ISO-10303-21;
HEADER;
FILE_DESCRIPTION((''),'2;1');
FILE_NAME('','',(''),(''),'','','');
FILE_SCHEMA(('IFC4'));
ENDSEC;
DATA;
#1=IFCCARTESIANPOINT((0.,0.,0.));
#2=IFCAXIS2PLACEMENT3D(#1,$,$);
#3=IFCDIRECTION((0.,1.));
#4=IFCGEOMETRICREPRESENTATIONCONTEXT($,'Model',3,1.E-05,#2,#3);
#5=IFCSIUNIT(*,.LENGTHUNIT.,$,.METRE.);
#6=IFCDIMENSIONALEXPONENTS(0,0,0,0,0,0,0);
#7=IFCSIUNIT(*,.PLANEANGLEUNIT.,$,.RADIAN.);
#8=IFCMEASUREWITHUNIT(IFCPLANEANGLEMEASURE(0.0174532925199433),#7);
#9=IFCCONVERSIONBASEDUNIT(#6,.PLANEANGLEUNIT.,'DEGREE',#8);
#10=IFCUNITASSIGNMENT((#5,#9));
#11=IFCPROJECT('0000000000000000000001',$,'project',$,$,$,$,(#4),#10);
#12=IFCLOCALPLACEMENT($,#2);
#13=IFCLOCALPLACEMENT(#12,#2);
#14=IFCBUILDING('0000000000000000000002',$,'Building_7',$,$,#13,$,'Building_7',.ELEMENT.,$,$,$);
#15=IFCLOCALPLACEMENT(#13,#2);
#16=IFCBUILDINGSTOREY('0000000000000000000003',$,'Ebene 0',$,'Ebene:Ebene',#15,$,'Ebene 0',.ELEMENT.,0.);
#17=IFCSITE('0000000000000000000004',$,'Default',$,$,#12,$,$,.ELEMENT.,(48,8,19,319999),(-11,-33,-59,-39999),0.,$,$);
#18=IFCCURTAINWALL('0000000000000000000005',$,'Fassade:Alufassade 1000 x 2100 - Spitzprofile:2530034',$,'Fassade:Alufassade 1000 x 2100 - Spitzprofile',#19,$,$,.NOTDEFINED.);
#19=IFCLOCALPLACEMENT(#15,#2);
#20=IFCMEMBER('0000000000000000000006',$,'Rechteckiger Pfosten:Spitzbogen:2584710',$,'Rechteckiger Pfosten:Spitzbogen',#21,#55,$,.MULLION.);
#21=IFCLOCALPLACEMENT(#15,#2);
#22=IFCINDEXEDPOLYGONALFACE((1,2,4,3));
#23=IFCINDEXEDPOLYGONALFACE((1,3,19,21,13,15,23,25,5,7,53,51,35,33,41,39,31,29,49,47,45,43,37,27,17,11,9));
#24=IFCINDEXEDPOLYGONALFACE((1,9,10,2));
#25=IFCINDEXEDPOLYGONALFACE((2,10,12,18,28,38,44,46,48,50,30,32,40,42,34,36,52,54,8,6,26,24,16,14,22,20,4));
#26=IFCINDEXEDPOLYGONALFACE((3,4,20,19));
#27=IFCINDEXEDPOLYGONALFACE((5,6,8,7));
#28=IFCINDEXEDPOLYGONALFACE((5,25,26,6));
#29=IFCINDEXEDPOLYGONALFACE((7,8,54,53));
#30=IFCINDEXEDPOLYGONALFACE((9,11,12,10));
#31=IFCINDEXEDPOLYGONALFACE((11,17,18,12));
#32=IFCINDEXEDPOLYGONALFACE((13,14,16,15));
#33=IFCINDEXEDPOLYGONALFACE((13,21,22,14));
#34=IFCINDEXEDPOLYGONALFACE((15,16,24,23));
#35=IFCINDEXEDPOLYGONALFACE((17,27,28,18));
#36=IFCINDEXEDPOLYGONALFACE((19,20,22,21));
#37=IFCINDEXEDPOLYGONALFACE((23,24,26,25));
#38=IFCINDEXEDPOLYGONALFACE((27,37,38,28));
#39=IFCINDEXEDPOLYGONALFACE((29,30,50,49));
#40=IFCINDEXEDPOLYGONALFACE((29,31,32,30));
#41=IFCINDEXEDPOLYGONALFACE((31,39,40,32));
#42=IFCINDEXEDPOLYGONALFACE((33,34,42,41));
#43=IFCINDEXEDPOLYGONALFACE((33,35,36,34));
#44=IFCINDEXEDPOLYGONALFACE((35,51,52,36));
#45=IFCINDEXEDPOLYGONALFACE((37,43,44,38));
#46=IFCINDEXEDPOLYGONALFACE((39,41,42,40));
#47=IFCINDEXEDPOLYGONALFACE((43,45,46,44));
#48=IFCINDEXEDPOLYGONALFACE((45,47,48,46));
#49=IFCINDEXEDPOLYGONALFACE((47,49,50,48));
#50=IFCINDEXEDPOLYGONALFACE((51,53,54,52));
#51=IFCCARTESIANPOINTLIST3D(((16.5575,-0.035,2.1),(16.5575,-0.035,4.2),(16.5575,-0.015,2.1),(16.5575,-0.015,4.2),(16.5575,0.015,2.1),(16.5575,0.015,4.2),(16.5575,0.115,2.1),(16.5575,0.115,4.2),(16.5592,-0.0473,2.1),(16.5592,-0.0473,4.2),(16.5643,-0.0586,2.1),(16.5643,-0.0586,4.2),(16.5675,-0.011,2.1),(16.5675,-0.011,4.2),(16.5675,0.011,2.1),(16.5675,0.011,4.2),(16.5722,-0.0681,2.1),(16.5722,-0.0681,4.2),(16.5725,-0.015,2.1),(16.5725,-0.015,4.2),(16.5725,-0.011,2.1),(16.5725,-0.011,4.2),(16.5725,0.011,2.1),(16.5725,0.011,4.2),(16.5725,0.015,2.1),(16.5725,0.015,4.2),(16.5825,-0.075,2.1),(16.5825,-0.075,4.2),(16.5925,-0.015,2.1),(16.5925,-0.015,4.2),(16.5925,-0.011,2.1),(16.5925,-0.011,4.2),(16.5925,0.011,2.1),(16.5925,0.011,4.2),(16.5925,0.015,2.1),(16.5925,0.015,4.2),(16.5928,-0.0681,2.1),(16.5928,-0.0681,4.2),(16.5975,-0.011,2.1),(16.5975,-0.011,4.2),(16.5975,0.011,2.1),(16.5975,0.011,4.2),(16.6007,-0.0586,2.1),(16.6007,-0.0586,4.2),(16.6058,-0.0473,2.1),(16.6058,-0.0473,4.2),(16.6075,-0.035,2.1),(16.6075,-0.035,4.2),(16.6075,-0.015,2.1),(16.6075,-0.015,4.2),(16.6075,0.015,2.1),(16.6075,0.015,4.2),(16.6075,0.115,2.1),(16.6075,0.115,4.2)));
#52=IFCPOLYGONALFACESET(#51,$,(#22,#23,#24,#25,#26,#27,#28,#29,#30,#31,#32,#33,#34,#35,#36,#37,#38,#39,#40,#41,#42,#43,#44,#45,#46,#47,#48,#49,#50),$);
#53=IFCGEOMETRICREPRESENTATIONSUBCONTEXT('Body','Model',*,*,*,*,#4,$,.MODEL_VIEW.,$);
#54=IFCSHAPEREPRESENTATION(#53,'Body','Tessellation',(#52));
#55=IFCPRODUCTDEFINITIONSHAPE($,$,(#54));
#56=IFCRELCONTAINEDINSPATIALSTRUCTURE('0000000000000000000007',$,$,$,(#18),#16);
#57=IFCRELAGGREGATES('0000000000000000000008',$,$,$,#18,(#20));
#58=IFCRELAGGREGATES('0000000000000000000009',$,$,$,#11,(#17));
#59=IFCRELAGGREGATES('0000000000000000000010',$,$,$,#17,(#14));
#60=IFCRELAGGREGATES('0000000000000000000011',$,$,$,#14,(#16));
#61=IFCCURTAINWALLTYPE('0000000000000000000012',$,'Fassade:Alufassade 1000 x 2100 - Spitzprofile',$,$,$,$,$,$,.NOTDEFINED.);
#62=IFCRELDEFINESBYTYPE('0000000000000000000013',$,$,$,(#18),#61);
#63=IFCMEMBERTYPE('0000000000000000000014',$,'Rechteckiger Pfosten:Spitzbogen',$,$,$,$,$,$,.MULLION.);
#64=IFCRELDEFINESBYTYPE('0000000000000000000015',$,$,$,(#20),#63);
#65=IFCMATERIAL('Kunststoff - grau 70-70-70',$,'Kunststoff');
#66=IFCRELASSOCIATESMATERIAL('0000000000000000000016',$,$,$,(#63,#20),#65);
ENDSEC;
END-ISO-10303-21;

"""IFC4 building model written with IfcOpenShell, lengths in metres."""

from ifc_helpers import new_model, entity, si_unit, converted_unit, direction, frame, origin, place, context, subcontext, project, spatial, line, arc, indexed_curve, outline, extrude, source, transform, mapped, material, type_object, type_shapes, element, aggregate, save


model = new_model("IFC4")

# Units and contexts
model_context = context("Model", 3, precision=1e-05, world=origin(), true_north=direction((0.0, 1.0)))
body_context = subcontext(model_context, "Body", "Model", "MODEL_VIEW")
ifc_project = project(units=[si_unit("LENGTHUNIT", "METRE"), converted_unit("PLANEANGLEUNIT", "DEGREE", entity("IfcPlaneAngleMeasure", 0.0174532925199433), si_unit("PLANEANGLEUNIT", "RADIAN"), dimensions=[0, 0, 0, 0, 0, 0, 0])], contexts=[model_context])

# Site, building, storey
site_placement = place(None, origin())
site = spatial("IfcSite", under=ifc_project, at=site_placement, Name="Default", CompositionType="ELEMENT", RefLatitude=(48, 8, 19, 319999), RefLongitude=(-11, -33, -59, -39999), RefElevation=0.0)
building_placement = place(site_placement, origin())
building = spatial("IfcBuilding", under=site, at=building_placement, Name="Building_7", LongName="Building_7", CompositionType="ELEMENT")
storey_placement = place(building_placement, origin())
storey = spatial("IfcBuildingStorey", under=building, at=storey_placement, Name="Ebene 0", ObjectType="Ebene:Ebene", LongName="Ebene 0", CompositionType="ELEMENT", Elevation=0.0)

# Curtain wall, member
curtain_wall_type = type_object("IfcCurtainWallType", Name="Fassade:Alufassade 1000 x 2100 - Spitzprofile", PredefinedType="NOTDEFINED")
curtain_wall_placement = place(storey_placement, origin())
curtain_wall = element("IfcCurtainWall", 1, at=curtain_wall_placement, inside=storey, type_object=curtain_wall_type, Name="Fassade:Alufassade 1000 x 2100 - Spitzprofile:2530034", ObjectType="Fassade:Alufassade 1000 x 2100 - Spitzprofile", PredefinedType="NOTDEFINED")
ifc_material = material(Name="Kunststoff - grau 70-70-70", Category="Kunststoff")
member_type_1 = type_object("IfcMemberType", Name="Rechteckiger Pfosten:Spitzbogen", PredefinedType="MULLION", material=ifc_material)
shared_shape_1 = source(origin(), body_context, "Body", "SweptSolid", [
    extrude(outline(indexed_curve([(-0.111, -0.025), (-0.011, -0.025), (-0.011, -0.01), (-0.007, -0.01), (-0.007, -0.015), (0.015, -0.015), (0.015, -0.01), (0.019, -0.01), (0.019, -0.025), (0.039, -0.025), (0.0626, -0.0182), (0.079, 0.0), (0.0626, 0.0182), (0.039, 0.025), (0.019, 0.025), (0.019, 0.01), (0.015, 0.01), (0.015, 0.015), (-0.007, 0.015), (-0.007, 0.01), (-0.011, 0.01), (-0.011, 0.025), (-0.111, 0.025)], segments=[line(1, 2, 3, 4, 5, 6, 7, 8, 9, 10), arc(10, 11, 12), arc(12, 13, 14), line(14, 15, 16, 17, 18, 19, 20, 21, 22, 23, 1)], self_intersect=False)), frame((0.0, 0.004, -2.1), z_axis=(0.0, 0.0, 1.0), x_axis=(0.0, -1.0, 0.0)), (0.0, 0.0, 1.0), 2.1),
])
type_shapes(member_type_1, [shared_shape_1])
member_1_placement = place(curtain_wall_placement, frame((16.5825, 0.0, 2.1), z_axis=(0.0, 0.0, -1.0), x_axis=(-1.0, 0.0, 0.0)))
member_1 = element("IfcMember", 2, at=member_1_placement, type_object=member_type_1, material=ifc_material, Name="Rechteckiger Pfosten:Spitzbogen:2584710", ObjectType="Rechteckiger Pfosten:Spitzbogen", PredefinedType="MULLION", context=body_context, shape_type="MappedRepresentation", body=[
    mapped(shared_shape_1, transform((0.0, 0.0, 0.0), scale=1.0)),
])
aggregate(curtain_wall, [member_1])

save(model, "model.ifc")
